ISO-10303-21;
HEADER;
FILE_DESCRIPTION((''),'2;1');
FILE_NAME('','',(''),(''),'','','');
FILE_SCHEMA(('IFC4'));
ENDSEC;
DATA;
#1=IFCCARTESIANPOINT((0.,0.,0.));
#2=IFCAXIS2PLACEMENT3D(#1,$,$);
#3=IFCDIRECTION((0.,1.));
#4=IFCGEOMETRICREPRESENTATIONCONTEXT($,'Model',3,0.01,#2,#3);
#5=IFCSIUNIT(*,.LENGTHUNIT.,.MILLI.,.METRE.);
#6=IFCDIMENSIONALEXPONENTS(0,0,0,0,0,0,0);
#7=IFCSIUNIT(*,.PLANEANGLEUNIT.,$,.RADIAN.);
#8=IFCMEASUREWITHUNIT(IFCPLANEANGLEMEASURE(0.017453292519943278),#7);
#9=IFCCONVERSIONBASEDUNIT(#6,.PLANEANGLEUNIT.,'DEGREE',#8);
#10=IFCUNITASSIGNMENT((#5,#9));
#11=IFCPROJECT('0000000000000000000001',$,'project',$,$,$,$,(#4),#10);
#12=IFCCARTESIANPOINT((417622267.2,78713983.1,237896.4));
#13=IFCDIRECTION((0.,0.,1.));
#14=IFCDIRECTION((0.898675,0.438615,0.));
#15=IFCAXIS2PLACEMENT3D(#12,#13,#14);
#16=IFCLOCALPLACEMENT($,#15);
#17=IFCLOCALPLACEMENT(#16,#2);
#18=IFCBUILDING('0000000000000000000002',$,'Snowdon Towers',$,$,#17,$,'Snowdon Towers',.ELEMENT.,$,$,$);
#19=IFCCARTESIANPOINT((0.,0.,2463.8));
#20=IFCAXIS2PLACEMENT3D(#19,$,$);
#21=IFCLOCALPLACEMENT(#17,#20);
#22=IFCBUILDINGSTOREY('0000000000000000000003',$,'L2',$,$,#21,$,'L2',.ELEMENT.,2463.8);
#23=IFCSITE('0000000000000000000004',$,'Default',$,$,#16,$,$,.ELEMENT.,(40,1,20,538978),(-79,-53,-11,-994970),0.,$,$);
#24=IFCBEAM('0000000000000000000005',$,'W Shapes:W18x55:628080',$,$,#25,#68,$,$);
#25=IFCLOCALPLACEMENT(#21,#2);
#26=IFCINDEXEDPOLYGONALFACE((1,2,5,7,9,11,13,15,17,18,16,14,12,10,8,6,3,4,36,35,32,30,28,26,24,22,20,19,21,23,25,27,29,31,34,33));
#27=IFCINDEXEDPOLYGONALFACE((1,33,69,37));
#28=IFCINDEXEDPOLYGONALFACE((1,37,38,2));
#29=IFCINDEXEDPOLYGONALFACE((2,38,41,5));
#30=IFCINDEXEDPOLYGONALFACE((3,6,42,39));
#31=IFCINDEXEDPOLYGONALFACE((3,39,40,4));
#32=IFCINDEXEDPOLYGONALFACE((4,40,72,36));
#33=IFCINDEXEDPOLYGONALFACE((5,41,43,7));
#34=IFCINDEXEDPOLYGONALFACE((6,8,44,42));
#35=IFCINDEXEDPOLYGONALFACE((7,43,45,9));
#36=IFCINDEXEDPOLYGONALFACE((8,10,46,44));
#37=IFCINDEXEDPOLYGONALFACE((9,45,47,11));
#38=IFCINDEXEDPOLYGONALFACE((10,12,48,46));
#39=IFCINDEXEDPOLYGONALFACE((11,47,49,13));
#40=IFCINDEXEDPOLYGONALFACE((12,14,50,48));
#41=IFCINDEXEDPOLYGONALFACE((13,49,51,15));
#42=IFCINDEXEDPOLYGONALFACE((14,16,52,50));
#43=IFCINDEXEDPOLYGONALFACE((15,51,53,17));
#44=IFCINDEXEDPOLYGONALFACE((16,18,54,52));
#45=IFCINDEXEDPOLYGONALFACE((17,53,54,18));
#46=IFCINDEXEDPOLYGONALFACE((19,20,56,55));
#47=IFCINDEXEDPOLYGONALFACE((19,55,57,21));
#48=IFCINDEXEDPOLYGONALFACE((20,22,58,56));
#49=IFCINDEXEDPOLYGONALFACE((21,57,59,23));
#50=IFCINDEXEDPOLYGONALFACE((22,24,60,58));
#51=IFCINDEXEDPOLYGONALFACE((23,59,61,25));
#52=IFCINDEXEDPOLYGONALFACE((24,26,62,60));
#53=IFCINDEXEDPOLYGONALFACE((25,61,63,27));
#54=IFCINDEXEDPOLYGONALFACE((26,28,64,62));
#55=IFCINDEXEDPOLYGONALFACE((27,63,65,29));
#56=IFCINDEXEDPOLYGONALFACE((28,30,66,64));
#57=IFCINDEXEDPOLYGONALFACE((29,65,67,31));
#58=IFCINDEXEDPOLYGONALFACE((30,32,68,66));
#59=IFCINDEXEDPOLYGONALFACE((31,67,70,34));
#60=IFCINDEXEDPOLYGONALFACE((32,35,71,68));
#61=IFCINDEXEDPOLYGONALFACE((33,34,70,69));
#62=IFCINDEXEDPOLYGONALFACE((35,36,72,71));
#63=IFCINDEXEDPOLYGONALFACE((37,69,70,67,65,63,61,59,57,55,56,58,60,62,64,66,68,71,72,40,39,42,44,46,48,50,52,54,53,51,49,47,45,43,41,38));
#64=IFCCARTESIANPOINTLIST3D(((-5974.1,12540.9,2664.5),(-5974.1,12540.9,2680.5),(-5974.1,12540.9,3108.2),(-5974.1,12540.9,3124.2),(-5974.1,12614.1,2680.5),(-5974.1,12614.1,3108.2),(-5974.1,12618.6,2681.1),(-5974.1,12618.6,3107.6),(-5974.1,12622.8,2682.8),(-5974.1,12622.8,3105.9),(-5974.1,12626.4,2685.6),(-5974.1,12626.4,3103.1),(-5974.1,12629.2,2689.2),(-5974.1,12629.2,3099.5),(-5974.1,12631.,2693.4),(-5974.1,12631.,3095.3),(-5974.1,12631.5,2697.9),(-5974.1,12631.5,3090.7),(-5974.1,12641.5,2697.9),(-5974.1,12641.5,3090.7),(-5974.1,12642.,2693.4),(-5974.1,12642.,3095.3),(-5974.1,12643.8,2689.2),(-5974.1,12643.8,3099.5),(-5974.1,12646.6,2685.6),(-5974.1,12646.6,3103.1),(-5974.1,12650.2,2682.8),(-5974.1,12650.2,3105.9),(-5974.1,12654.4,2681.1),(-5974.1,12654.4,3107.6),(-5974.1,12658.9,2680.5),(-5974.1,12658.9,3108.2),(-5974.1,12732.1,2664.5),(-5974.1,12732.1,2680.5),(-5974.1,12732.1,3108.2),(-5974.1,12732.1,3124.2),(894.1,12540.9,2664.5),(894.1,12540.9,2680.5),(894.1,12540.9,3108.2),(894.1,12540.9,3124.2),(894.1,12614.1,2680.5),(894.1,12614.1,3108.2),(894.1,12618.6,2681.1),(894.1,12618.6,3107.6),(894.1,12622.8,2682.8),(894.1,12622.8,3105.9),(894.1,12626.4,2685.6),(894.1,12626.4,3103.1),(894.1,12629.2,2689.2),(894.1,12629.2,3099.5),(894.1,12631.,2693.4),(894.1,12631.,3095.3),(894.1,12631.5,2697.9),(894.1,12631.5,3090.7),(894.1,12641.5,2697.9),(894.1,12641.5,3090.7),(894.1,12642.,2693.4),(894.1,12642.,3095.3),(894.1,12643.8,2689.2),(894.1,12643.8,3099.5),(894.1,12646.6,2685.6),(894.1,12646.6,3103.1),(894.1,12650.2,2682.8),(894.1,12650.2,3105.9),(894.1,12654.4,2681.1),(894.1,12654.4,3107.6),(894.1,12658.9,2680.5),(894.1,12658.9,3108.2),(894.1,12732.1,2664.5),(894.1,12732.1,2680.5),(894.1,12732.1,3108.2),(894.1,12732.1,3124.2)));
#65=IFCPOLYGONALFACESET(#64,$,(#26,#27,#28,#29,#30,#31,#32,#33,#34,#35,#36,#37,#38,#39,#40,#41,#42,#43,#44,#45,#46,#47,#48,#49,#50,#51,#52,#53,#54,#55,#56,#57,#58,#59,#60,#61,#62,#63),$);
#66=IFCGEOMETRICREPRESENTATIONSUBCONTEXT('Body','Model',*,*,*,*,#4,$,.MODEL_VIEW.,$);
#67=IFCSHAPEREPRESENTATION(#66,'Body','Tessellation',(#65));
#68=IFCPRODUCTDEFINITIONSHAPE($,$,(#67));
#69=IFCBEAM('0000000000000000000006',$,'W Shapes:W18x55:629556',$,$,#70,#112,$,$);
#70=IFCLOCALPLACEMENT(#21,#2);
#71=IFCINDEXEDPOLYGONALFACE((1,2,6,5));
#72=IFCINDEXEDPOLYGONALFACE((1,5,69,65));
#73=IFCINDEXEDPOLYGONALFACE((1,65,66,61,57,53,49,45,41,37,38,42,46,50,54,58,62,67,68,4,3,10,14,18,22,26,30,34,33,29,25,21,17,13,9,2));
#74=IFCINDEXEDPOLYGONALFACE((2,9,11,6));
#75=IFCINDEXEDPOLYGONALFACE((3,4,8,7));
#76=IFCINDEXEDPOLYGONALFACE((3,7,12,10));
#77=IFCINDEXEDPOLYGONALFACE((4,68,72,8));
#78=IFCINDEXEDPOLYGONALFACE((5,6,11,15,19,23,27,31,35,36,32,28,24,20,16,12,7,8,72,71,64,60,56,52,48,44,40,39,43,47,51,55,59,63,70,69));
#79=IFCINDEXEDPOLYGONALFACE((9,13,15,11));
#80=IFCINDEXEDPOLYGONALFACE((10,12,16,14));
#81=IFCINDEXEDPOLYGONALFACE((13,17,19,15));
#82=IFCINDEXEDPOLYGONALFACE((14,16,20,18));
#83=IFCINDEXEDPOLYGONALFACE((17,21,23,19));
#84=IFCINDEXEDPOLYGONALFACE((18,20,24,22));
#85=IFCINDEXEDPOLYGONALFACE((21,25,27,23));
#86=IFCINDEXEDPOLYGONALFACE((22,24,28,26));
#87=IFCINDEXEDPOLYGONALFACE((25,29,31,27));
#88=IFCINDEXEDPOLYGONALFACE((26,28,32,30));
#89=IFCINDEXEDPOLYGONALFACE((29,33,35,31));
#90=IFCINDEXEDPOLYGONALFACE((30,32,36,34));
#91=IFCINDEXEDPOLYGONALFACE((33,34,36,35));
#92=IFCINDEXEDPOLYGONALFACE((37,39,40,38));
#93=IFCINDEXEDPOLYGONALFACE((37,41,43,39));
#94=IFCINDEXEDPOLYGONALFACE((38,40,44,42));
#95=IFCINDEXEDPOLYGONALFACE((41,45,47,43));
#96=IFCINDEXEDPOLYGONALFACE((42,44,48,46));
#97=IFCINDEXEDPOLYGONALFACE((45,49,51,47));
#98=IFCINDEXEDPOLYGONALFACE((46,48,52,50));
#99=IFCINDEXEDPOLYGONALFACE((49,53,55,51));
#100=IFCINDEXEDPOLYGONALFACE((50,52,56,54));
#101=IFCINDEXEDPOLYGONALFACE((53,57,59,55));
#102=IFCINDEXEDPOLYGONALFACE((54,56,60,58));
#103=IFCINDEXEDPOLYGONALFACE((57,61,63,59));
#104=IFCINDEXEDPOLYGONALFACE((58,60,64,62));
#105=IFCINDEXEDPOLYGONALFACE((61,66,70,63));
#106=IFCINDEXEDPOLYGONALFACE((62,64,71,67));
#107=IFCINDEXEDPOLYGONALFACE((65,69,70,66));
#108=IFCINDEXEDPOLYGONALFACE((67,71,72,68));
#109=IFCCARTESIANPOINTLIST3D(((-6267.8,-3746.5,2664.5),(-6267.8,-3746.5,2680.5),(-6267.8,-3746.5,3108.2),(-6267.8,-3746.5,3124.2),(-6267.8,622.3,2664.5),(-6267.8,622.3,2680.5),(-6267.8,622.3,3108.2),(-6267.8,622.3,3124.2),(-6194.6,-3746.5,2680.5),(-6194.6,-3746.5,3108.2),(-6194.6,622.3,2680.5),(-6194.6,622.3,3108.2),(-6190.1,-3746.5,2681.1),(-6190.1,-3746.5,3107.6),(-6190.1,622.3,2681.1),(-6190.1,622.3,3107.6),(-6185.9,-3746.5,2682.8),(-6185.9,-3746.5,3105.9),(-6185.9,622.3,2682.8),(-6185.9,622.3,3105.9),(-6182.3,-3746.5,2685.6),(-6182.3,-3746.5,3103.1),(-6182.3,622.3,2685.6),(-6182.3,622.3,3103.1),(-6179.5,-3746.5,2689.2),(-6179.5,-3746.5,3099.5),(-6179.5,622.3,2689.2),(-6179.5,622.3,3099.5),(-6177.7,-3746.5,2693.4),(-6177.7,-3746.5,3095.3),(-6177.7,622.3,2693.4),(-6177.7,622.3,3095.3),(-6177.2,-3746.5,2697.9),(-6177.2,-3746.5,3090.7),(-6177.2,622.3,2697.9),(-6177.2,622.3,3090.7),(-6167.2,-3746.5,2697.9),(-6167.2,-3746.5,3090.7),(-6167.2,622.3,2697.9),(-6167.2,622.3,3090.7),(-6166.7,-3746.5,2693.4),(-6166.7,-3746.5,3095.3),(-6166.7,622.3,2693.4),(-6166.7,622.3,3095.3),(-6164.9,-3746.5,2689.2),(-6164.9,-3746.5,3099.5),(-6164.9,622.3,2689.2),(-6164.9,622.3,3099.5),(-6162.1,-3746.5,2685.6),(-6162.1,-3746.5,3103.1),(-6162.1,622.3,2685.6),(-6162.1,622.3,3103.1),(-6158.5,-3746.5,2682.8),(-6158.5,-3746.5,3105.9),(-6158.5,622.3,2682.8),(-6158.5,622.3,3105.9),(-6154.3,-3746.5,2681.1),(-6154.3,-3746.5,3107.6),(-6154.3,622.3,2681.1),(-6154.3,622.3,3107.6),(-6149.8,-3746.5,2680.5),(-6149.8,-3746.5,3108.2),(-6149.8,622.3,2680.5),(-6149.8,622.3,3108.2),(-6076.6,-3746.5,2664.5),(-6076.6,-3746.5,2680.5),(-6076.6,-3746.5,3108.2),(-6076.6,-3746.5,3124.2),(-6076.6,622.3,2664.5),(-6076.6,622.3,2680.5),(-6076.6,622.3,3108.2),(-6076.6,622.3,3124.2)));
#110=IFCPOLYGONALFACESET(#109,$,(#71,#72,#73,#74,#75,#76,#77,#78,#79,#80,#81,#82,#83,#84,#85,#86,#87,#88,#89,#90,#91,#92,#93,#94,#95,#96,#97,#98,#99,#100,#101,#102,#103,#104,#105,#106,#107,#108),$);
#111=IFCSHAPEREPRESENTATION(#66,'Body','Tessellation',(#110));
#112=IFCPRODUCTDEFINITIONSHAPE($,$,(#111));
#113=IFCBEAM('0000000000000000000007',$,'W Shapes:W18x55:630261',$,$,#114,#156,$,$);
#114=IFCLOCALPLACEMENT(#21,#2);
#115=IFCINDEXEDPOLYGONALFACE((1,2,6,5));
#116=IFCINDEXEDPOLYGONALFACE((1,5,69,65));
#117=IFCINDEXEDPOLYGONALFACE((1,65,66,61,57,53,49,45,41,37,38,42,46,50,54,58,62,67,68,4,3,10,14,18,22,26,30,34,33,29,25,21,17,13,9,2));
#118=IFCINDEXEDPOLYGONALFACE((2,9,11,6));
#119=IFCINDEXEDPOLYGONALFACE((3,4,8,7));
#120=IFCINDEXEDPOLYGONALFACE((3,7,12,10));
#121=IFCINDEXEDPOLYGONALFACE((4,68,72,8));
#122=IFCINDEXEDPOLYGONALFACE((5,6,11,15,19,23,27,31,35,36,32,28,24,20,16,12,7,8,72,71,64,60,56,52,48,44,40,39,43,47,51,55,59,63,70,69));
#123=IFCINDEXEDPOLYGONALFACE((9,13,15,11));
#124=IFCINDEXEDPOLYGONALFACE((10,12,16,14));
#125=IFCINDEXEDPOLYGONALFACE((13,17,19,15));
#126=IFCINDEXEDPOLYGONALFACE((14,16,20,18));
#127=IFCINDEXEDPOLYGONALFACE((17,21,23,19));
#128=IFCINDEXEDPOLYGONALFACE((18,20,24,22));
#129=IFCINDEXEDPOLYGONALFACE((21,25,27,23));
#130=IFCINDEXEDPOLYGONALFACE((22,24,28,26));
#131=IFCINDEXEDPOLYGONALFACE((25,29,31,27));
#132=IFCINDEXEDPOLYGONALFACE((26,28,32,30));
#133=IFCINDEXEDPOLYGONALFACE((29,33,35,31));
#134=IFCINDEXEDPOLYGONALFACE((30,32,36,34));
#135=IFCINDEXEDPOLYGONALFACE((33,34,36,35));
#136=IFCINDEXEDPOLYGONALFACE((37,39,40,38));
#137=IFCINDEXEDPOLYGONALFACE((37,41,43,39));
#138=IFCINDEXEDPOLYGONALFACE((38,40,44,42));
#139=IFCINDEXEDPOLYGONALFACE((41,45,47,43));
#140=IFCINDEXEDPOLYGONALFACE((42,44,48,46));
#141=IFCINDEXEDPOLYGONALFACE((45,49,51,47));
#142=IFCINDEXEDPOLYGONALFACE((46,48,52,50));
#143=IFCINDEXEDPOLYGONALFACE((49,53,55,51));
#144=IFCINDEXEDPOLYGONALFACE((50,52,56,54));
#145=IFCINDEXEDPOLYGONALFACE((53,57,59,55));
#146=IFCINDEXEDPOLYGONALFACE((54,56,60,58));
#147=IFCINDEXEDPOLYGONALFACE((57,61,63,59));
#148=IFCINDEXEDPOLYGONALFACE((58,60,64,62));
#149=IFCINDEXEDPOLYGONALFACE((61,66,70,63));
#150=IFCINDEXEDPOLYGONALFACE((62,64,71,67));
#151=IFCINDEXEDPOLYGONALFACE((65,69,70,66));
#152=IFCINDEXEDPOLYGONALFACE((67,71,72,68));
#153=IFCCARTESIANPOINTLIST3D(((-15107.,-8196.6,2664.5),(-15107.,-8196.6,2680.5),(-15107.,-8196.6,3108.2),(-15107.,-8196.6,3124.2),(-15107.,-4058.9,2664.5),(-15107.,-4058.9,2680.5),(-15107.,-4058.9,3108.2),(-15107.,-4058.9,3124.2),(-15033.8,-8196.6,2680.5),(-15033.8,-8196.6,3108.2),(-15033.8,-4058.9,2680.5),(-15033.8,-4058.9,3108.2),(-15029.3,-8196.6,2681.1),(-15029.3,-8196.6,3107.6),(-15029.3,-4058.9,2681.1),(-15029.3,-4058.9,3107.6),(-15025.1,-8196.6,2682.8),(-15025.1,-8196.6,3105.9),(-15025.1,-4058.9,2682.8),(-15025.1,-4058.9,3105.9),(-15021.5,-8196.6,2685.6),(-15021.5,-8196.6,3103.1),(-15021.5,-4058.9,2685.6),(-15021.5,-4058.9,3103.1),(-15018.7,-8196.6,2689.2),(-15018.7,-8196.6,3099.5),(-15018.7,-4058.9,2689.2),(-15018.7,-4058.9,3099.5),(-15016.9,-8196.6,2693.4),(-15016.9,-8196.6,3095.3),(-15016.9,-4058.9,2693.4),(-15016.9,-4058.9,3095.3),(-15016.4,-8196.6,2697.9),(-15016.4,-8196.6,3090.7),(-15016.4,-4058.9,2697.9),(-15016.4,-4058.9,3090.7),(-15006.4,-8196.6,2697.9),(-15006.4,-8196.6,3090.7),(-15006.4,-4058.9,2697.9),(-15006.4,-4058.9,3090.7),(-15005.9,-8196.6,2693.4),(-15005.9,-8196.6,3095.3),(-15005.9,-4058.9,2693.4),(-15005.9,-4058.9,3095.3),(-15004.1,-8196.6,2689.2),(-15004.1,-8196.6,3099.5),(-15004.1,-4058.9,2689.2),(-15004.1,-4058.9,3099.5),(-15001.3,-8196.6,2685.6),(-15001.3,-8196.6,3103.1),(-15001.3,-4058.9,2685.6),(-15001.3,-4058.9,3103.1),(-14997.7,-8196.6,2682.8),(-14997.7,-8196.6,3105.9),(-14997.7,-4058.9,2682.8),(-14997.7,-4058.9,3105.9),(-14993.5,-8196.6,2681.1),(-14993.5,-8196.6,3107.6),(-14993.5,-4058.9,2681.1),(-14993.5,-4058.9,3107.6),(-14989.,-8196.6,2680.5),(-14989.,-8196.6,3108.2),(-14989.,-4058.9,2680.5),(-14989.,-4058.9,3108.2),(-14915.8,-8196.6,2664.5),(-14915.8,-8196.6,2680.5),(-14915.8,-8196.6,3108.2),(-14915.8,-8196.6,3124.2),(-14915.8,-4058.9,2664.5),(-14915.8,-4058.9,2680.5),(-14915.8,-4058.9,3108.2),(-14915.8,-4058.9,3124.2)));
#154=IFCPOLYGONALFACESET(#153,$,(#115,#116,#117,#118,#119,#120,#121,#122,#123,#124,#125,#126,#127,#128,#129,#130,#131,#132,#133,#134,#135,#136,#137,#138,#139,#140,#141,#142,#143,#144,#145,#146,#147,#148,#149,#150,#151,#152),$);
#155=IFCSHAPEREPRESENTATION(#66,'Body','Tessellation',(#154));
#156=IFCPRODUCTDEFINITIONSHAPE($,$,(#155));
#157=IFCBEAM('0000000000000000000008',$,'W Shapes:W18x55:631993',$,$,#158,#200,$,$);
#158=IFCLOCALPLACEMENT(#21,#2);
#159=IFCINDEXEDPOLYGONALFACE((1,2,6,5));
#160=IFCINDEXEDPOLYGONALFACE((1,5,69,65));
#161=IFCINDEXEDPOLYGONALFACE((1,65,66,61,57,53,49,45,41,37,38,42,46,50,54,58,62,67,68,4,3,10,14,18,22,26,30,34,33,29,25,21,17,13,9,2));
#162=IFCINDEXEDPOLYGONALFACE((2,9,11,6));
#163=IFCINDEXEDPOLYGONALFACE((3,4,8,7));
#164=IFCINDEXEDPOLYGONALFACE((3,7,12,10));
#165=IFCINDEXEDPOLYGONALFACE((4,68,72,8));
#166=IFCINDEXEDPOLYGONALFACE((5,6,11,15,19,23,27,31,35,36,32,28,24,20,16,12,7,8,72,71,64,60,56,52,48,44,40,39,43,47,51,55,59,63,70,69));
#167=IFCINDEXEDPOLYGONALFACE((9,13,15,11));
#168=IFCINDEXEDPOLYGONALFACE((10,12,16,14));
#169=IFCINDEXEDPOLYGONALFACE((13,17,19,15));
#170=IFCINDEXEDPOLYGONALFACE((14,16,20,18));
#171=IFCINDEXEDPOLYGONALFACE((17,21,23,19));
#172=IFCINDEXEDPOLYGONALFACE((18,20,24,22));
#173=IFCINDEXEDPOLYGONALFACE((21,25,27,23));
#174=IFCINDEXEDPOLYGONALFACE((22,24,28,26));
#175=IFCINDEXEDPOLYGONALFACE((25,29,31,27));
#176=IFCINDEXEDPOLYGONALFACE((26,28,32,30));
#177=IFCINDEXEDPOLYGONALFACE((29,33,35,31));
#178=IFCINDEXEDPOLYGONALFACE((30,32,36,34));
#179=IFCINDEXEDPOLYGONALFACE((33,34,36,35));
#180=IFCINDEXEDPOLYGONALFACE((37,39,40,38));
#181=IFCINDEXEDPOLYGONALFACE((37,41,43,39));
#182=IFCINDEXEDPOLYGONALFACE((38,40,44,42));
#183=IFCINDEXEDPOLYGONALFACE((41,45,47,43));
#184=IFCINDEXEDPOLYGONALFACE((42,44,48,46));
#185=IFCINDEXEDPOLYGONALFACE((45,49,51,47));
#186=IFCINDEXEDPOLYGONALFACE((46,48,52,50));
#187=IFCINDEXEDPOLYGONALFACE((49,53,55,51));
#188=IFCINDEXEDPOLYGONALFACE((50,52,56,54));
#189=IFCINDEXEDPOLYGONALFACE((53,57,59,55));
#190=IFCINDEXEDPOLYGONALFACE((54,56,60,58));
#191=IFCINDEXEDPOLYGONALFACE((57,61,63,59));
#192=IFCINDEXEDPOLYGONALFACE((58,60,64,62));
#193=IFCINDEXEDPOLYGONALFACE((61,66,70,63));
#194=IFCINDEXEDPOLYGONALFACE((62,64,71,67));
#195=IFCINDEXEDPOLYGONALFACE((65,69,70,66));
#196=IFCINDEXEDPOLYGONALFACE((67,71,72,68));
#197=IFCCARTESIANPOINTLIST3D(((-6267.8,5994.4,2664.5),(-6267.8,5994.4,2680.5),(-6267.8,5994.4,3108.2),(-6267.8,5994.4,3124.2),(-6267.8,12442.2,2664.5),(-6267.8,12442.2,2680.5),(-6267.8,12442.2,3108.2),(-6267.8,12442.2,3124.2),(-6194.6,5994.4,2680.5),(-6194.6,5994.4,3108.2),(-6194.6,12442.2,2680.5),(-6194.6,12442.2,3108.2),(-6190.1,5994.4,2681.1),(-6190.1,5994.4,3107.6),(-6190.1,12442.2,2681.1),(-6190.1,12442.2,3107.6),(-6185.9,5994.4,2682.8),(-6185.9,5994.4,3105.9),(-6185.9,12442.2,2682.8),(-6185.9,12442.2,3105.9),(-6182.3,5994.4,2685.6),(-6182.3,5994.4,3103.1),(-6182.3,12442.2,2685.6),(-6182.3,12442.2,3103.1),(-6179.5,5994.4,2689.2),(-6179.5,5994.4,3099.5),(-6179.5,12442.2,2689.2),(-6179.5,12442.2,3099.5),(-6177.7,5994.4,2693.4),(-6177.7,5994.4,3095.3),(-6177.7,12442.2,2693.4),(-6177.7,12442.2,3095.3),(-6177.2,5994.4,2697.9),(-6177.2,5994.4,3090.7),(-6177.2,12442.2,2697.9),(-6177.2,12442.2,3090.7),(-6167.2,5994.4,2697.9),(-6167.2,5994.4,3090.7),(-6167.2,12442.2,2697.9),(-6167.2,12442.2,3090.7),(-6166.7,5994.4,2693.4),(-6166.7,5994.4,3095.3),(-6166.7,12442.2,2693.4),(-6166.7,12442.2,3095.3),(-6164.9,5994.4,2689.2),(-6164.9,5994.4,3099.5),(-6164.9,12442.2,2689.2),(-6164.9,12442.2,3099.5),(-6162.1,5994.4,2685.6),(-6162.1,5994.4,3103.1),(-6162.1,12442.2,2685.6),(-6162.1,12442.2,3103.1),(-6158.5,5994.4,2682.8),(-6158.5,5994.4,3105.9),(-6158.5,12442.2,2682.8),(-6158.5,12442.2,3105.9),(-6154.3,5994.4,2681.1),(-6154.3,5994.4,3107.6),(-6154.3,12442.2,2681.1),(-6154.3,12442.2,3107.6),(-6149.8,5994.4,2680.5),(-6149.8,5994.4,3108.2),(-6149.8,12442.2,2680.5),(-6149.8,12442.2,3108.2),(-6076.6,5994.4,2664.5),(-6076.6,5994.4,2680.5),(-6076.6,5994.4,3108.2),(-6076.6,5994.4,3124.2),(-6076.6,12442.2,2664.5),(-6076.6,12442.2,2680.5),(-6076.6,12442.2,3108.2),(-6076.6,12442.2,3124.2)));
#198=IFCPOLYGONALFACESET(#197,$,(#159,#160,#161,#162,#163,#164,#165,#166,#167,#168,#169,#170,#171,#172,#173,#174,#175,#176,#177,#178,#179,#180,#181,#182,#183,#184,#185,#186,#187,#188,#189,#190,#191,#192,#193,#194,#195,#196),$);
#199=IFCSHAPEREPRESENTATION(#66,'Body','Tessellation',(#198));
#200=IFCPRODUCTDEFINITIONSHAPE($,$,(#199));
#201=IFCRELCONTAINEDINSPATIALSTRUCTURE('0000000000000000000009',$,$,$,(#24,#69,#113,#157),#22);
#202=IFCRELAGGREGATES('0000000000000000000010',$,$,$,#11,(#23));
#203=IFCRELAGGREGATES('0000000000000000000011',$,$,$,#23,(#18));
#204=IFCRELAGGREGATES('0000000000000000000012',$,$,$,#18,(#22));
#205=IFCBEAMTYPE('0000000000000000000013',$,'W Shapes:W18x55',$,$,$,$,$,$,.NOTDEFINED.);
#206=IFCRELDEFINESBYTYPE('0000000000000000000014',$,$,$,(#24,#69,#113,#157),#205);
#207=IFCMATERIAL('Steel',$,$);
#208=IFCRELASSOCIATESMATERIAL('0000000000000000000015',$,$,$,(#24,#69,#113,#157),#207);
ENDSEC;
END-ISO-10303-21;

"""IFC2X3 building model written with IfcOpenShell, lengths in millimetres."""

from ifc_helpers import new_model, entity, si_unit, converted_unit, direction, frame, frame_2d, origin, place, context, subcontext, project, spatial, i_section, extrude, material, type_object, element, save


model = new_model("IFC2X3")

# Units and contexts
model_context = context("Model", 3, precision=0.01, world=origin(), true_north=direction((0.0, 1.0)))
body_context = subcontext(model_context, "Body", "Model", "MODEL_VIEW")
ifc_project = project(units=[si_unit("LENGTHUNIT", "METRE", prefix="MILLI"), converted_unit("PLANEANGLEUNIT", "DEGREE", entity("IfcPlaneAngleMeasure", 0.017453292519943278), si_unit("PLANEANGLEUNIT", "RADIAN"), dimensions=[0, 0, 0, 0, 0, 0, 0])], contexts=[model_context])

# Site, building, storey
site_placement = place(None, frame((417622267.2, 78713983.1, 237896.4), z_axis=(0.0, 0.0, 1.0), x_axis=(0.898675, 0.438615, 0.0)))
site = spatial("IfcSite", under=ifc_project, at=site_placement, Name="Default", CompositionType="ELEMENT", RefLatitude=(40, 1, 20, 538978), RefLongitude=(-79, -53, -11, -994970), RefElevation=0.0)
building_placement = place(site_placement, origin())
building = spatial("IfcBuilding", under=site, at=building_placement, Name="Snowdon Towers", LongName="Snowdon Towers", CompositionType="ELEMENT")
storey_placement = place(building_placement, frame((0.0, 0.0, 2463.8)))
storey = spatial("IfcBuildingStorey", under=building, at=storey_placement, Name="L2", LongName="L2", CompositionType="ELEMENT", Elevation=2463.8)

# Beams
ifc_material_1 = material(Name="Steel")
beam_type_1 = type_object("IfcBeamType", Name="W Shapes:W18x55", PredefinedType="NOTDEFINED")
beam_1_placement = place(storey_placement, frame((-6172.2, 12636.5, 3124.2)))
element("IfcBeam", 1, at=beam_1_placement, inside=storey, type_object=beam_type_1, material=ifc_material_1, Name="W Shapes:W18x55:628080", context=body_context, shape_type="SweptSolid", body=[
    extrude(i_section(OverallWidth=191.3, OverallDepth=459.7, WebThickness=9.9, FlangeThickness=16.0, FilletRadius=17.5, at=frame_2d((0.0, 0.0), x_axis=(0.0, 1.0))), frame((198.1, 0.0, -229.9), z_axis=(1.0, 0.0, 0.0), x_axis=(0.0, 0.0, -1.0)), (0.0, 0.0, 1.0), 6868.2),
])
beam_2_placement = place(storey_placement, frame((-6172.2, 762.0, 3124.2), z_axis=(0.0, 0.0, 1.0), x_axis=(0.0, -1.0, 0.0)))
element("IfcBeam", 2, at=beam_2_placement, inside=storey, type_object=beam_type_1, material=ifc_material_1, Name="W Shapes:W18x55:629556", context=body_context, shape_type="SweptSolid", body=[
    extrude(i_section(OverallWidth=191.3, OverallDepth=459.7, WebThickness=9.9, FlangeThickness=16.0, FilletRadius=17.5, at=frame_2d((0.0, 0.0), x_axis=(0.0, 1.0))), frame((139.7, 0.0, -229.9), z_axis=(1.0, 0.0, 0.0), x_axis=(0.0, 0.0, -1.0)), (0.0, 0.0, 1.0), 4368.8),
])
beam_3_placement = place(storey_placement, frame((-15011.4, -3873.5, 3124.2), z_axis=(0.0, 0.0, 1.0), x_axis=(0.0, -1.0, 0.0)))
element("IfcBeam", 3, at=beam_3_placement, inside=storey, type_object=beam_type_1, material=ifc_material_1, Name="W Shapes:W18x55:630261", context=body_context, shape_type="SweptSolid", body=[
    extrude(i_section(OverallWidth=191.3, OverallDepth=459.7, WebThickness=9.9, FlangeThickness=16.0, FilletRadius=17.5, at=frame_2d((0.0, 0.0), x_axis=(0.0, 1.0))), frame((185.4, 0.0, -229.9), z_axis=(1.0, 0.0, 0.0), x_axis=(0.0, 0.0, -1.0)), (0.0, 0.0, 1.0), 4137.7),
])
beam_4_placement = place(storey_placement, frame((-6172.2, 12636.5, 3124.2), z_axis=(0.0, 0.0, 1.0), x_axis=(0.0, -1.0, 0.0)))
element("IfcBeam", 4, at=beam_4_placement, inside=storey, type_object=beam_type_1, material=ifc_material_1, Name="W Shapes:W18x55:631993", context=body_context, shape_type="SweptSolid", body=[
    extrude(i_section(OverallWidth=191.3, OverallDepth=459.7, WebThickness=9.9, FlangeThickness=16.0, FilletRadius=17.5, at=frame_2d((0.0, 0.0), x_axis=(0.0, 1.0))), frame((194.3, 0.0, -229.9), z_axis=(1.0, 0.0, 0.0), x_axis=(0.0, 0.0, -1.0)), (0.0, 0.0, 1.0), 6447.8),
])

save(model, "model.ifc")
